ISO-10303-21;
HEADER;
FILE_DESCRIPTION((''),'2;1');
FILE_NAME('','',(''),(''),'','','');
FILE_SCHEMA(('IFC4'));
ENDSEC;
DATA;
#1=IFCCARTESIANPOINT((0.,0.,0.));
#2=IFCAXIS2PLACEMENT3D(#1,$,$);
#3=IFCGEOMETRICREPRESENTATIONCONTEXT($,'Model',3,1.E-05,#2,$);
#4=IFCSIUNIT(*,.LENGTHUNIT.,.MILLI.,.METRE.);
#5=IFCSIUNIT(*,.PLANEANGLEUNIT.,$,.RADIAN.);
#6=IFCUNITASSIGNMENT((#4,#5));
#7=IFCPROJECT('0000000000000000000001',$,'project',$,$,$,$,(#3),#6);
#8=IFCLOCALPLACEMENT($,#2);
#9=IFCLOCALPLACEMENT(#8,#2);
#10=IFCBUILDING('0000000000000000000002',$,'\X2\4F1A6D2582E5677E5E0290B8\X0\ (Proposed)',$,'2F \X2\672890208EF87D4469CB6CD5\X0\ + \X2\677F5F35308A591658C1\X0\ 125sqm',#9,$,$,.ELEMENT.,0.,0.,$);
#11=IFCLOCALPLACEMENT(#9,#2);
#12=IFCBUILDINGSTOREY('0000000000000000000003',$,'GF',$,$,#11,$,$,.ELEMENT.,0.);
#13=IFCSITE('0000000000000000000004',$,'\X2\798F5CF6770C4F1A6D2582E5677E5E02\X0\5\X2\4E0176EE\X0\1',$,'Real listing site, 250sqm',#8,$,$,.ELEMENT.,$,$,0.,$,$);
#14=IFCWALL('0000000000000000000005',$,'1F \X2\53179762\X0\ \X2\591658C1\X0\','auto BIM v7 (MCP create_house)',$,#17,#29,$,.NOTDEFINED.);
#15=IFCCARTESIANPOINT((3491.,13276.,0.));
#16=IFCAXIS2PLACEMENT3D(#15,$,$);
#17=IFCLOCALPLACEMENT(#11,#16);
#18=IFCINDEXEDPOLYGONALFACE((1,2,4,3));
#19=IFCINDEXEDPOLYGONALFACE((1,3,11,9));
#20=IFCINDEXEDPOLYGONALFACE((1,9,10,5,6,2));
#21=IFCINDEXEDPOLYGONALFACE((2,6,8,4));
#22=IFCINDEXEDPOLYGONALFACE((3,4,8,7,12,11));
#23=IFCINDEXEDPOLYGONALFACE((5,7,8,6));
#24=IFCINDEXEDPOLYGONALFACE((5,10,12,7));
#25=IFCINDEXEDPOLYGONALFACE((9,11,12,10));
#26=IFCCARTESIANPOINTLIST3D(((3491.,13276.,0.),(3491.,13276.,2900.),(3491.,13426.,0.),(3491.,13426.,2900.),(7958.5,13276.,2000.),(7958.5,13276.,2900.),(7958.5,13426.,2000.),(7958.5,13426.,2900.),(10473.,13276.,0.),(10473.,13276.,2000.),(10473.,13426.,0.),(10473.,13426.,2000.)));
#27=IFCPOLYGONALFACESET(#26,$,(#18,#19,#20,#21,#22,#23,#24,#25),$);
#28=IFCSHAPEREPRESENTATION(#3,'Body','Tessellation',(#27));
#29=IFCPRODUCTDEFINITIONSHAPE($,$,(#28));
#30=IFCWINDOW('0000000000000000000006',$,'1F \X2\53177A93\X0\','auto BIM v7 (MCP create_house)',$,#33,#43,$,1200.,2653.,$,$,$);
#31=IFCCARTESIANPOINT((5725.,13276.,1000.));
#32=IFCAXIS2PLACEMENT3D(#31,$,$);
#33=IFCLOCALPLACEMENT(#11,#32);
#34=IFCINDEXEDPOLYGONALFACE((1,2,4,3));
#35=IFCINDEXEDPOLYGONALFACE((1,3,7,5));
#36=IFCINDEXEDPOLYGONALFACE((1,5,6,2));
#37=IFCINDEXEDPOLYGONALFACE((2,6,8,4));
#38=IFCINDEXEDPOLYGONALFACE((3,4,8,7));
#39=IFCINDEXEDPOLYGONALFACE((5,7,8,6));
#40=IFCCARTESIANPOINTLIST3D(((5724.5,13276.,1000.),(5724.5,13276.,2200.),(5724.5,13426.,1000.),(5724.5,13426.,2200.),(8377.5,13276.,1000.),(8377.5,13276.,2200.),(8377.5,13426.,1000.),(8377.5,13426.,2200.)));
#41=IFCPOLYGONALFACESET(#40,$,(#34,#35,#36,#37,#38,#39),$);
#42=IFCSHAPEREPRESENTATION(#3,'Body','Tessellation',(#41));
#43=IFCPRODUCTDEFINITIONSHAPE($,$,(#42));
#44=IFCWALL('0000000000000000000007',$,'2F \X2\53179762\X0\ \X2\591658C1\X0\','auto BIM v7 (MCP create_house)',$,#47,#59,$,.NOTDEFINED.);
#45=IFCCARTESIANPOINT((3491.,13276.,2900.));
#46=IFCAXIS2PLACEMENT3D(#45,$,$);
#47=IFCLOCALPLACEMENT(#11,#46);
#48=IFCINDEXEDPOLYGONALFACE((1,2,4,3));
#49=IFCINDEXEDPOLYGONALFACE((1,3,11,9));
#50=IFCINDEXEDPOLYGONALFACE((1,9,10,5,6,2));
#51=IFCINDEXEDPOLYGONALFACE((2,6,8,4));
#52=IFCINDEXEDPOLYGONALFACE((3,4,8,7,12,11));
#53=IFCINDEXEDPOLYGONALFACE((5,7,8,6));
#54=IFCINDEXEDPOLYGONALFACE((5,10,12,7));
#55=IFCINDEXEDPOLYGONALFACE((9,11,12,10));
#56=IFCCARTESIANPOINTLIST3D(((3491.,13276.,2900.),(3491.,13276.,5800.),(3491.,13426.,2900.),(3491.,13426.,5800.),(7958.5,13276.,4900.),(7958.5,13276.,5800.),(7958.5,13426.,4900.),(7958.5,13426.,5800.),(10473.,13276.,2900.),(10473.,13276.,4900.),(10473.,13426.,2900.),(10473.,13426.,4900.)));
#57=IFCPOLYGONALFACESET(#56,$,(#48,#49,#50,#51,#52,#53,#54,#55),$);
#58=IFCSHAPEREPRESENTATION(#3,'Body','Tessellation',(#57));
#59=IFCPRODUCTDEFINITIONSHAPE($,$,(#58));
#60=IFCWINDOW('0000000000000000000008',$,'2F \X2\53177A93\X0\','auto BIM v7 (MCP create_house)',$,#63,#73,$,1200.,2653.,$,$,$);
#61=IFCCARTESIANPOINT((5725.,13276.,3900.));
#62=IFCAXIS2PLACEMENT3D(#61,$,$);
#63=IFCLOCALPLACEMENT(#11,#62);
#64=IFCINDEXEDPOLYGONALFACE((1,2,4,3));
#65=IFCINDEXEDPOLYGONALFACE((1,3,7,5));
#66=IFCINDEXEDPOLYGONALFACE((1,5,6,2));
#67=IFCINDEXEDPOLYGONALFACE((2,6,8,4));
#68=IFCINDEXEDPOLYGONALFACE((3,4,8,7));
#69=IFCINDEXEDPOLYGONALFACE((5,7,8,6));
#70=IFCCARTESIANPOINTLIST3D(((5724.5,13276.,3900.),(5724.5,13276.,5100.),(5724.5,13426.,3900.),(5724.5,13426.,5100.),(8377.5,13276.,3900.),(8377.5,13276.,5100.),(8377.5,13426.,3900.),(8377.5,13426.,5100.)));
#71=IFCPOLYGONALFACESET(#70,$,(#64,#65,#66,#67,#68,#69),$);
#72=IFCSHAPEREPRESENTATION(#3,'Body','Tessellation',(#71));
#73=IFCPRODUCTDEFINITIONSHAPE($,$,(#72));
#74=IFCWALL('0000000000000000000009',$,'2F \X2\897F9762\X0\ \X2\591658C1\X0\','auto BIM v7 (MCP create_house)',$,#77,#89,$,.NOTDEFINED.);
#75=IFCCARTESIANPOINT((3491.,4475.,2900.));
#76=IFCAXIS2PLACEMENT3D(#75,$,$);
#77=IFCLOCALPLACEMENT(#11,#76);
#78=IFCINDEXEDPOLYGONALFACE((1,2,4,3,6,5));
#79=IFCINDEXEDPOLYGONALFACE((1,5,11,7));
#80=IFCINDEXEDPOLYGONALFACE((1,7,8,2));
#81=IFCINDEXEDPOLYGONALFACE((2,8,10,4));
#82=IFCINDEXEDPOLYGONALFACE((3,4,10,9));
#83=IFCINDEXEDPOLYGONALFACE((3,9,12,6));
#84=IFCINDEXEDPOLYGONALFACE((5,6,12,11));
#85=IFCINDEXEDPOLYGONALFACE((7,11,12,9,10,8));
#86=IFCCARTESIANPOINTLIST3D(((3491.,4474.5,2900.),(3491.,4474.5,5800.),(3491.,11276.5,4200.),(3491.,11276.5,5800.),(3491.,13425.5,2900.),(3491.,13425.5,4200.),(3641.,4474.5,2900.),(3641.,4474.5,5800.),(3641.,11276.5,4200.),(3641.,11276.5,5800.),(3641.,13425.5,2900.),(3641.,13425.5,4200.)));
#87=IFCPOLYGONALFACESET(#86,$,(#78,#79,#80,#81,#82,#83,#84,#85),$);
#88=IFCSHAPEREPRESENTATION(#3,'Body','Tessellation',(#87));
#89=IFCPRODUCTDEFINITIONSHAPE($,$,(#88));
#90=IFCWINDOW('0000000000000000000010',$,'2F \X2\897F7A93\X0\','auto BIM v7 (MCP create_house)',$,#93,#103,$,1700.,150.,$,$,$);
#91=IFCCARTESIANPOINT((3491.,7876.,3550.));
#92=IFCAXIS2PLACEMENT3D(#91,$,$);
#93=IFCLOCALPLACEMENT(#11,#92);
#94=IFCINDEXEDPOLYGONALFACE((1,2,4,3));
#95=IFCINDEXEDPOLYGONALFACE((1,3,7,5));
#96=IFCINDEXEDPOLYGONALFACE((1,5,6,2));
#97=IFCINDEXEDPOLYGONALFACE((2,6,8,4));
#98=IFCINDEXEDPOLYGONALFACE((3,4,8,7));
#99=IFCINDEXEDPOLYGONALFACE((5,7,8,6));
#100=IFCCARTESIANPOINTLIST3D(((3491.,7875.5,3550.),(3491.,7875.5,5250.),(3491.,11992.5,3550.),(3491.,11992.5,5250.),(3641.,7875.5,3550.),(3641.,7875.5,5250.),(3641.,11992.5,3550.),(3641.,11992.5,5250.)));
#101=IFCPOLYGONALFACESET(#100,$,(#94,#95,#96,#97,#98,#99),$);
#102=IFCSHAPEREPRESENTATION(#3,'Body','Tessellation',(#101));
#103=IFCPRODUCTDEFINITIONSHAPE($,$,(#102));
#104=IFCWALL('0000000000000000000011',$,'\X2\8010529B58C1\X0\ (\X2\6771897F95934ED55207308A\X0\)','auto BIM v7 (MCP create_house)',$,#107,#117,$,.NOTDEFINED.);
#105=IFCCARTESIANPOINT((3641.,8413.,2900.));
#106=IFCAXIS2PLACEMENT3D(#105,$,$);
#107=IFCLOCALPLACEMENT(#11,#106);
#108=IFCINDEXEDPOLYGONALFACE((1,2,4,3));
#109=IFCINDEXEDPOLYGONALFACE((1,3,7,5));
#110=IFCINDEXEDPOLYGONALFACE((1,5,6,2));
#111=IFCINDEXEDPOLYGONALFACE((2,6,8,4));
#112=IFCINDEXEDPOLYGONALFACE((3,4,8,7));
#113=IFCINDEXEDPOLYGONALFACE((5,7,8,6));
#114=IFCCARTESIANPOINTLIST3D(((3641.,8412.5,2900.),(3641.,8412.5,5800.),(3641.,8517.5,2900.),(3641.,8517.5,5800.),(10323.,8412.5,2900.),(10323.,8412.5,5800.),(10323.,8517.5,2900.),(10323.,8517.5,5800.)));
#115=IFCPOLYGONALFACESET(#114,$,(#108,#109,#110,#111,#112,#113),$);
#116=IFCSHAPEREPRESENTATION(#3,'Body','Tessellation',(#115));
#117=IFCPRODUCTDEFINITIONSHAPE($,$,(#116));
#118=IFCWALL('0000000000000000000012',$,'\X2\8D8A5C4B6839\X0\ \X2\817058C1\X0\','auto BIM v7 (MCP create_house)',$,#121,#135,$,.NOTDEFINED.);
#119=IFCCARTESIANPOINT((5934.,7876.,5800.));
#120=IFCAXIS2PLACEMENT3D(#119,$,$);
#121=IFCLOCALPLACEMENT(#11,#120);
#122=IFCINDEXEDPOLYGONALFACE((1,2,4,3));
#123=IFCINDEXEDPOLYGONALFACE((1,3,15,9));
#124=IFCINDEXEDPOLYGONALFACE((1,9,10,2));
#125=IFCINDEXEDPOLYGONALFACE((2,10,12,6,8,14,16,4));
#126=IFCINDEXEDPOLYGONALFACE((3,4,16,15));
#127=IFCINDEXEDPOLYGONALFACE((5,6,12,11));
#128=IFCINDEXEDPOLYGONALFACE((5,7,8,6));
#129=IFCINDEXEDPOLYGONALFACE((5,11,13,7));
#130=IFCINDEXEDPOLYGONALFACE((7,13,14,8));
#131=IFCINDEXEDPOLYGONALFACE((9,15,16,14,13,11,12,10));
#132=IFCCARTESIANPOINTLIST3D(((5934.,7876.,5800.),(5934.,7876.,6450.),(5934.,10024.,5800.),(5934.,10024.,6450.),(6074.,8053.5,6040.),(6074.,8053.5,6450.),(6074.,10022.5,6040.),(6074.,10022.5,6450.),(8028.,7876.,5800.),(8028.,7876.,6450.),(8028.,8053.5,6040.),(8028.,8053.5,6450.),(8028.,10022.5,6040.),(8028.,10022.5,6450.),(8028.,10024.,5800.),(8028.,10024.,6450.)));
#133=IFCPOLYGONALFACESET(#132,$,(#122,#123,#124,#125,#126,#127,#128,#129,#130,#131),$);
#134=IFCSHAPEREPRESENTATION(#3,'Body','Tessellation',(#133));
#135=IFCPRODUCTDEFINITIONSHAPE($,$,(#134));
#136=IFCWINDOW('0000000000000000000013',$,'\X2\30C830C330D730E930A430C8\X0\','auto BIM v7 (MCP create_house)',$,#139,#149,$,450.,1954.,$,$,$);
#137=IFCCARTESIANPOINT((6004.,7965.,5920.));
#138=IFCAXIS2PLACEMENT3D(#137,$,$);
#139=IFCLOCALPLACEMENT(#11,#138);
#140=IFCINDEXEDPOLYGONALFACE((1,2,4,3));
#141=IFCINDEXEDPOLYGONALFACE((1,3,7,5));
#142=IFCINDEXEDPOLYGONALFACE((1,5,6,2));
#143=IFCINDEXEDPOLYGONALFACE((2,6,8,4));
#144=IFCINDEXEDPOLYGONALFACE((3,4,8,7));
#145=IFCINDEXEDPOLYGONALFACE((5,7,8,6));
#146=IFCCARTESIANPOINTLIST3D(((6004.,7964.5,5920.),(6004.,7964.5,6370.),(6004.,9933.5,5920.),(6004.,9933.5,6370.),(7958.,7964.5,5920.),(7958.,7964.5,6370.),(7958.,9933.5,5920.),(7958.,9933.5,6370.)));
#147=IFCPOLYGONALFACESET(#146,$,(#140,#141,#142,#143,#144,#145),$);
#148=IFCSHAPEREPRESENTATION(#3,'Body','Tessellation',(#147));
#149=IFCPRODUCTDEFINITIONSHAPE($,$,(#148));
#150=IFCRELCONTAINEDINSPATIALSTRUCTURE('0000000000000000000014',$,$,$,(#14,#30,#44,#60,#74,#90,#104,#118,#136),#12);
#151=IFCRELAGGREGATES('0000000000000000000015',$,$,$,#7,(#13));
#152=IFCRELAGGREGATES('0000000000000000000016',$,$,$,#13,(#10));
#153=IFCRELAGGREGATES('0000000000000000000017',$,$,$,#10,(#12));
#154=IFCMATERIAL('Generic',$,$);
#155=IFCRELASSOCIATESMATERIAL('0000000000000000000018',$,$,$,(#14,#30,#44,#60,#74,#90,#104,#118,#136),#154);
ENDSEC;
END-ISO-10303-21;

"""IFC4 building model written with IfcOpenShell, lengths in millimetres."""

from ifc_helpers import new_model, si_unit, frame, frame_2d, origin, place, context, project, spatial, rectangle, extrude, material, element, fill, save


model = new_model("IFC4")

# Units and contexts
model_context = context("Model", 3, precision=1e-05, world=origin())
ifc_project = project(units=[si_unit("LENGTHUNIT", "METRE", prefix="MILLI"), si_unit("PLANEANGLEUNIT", "RADIAN")], contexts=[model_context])

# Site, building, storey
site_placement = place(None, origin())
site = spatial("IfcSite", under=ifc_project, at=site_placement, Name="福島県会津若松市5丁目1", ObjectType="Real listing site, 250sqm", CompositionType="ELEMENT", RefElevation=0.0)
building_placement = place(site_placement, origin())
building = spatial("IfcBuilding", under=site, at=building_placement, Name="会津若松市邸 (Proposed)", ObjectType="2F 木造軸組構法 + 板張り外壁 125sqm", CompositionType="ELEMENT", ElevationOfRefHeight=0.0, ElevationOfTerrain=0.0)
storey_placement = place(building_placement, origin())
storey = spatial("IfcBuildingStorey", under=building, at=storey_placement, Name="GF", CompositionType="ELEMENT", Elevation=0.0)

# Wall, opening, window
ifc_material = material(Name="Generic")
wall_1_placement = place(storey_placement, frame((3491.0, 13276.0, 0.0)))
wall_1 = element("IfcWall", 1, at=wall_1_placement, inside=storey, material=ifc_material, Name="1F 北面 外壁", Description="auto BIM v7 (MCP create_house)", PredefinedType="NOTDEFINED", context=model_context, shape_type="SweptSolid", body=[
    extrude(rectangle(XDim=6982.0, YDim=150.0, at=frame_2d((3491.0, 75.0))), frame((3491.0, 13276.0, 0.0)), (0.0, 0.0, 1.0), 2900.0),
])
opening_1_placement = place(storey_placement, frame((5725.0, 13276.0, 1000.0)))
opening_1 = element("IfcOpeningElement", 2, at=opening_1_placement, cuts=wall_1, PredefinedType="NOTDEFINED", context=model_context, shape_type="SweptSolid", body=[
    extrude(rectangle(XDim=2653.0, YDim=150.0, at=frame_2d((1326.0, 75.0))), frame((5725.0, 13276.0, 1000.0)), (0.0, 0.0, 1.0), 1200.0),
])
window_1_placement = place(storey_placement, frame((5725.0, 13276.0, 1000.0)))
window_1 = element("IfcWindow", 3, at=window_1_placement, inside=storey, material=ifc_material, Name="1F 北窓", Description="auto BIM v7 (MCP create_house)", OverallHeight=1200.0, OverallWidth=2653.0, context=model_context, shape_type="SweptSolid", body=[
    extrude(rectangle(XDim=2653.0, YDim=150.0, at=frame_2d((1326.0, 75.0))), frame((5725.0, 13276.0, 1000.0)), (0.0, 0.0, 1.0), 1200.0),
])
fill(opening_1, window_1)

# Walls, openings, windows
wall_2_placement = place(storey_placement, frame((3491.0, 13276.0, 2900.0)))
wall_2 = element("IfcWall", 4, at=wall_2_placement, inside=storey, material=ifc_material, Name="2F 北面 外壁", Description="auto BIM v7 (MCP create_house)", PredefinedType="NOTDEFINED", context=model_context, shape_type="SweptSolid", body=[
    extrude(rectangle(XDim=6982.0, YDim=150.0, at=frame_2d((3491.0, 75.0))), frame((3491.0, 13276.0, 2900.0)), (0.0, 0.0, 1.0), 2900.0),
])
opening_2_placement = place(storey_placement, frame((5725.0, 13276.0, 3900.0)))
opening_2 = element("IfcOpeningElement", 5, at=opening_2_placement, cuts=wall_2, PredefinedType="NOTDEFINED", context=model_context, shape_type="SweptSolid", body=[
    extrude(rectangle(XDim=2653.0, YDim=150.0, at=frame_2d((1326.0, 75.0))), frame((5725.0, 13276.0, 3900.0)), (0.0, 0.0, 1.0), 1200.0),
])
window_2_placement = place(storey_placement, frame((5725.0, 13276.0, 3900.0)))
window_2 = element("IfcWindow", 6, at=window_2_placement, inside=storey, material=ifc_material, Name="2F 北窓", Description="auto BIM v7 (MCP create_house)", OverallHeight=1200.0, OverallWidth=2653.0, context=model_context, shape_type="SweptSolid", body=[
    extrude(rectangle(XDim=2653.0, YDim=150.0, at=frame_2d((1326.0, 75.0))), frame((5725.0, 13276.0, 3900.0)), (0.0, 0.0, 1.0), 1200.0),
])
fill(opening_2, window_2)
wall_3_placement = place(storey_placement, frame((3491.0, 4475.0, 2900.0)))
wall_3 = element("IfcWall", 7, at=wall_3_placement, inside=storey, material=ifc_material, Name="2F 西面 外壁", Description="auto BIM v7 (MCP create_house)", PredefinedType="NOTDEFINED", context=model_context, shape_type="SweptSolid", body=[
    extrude(rectangle(XDim=150.0, YDim=8951.0, at=frame_2d((75.0, 4475.0))), frame((3491.0, 4475.0, 2900.0)), (0.0, 0.0, 1.0), 2900.0),
])
opening_3_placement = place(storey_placement, frame((3491.0, 7876.0, 3550.0)))
opening_3 = element("IfcOpeningElement", 8, at=opening_3_placement, cuts=wall_3, PredefinedType="NOTDEFINED", context=model_context, shape_type="SweptSolid", body=[
    extrude(rectangle(XDim=150.0, YDim=4117.0, at=frame_2d((75.0, 2058.0))), frame((3491.0, 7876.0, 3550.0)), (0.0, 0.0, 1.0), 1700.0),
])
window_3_placement = place(storey_placement, frame((3491.0, 7876.0, 3550.0)))
window_3 = element("IfcWindow", 9, at=window_3_placement, inside=storey, material=ifc_material, Name="2F 西窓", Description="auto BIM v7 (MCP create_house)", OverallHeight=1700.0, OverallWidth=150.0, context=model_context, shape_type="SweptSolid", body=[
    extrude(rectangle(XDim=150.0, YDim=4117.0, at=frame_2d((75.0, 2058.0))), frame((3491.0, 7876.0, 3550.0)), (0.0, 0.0, 1.0), 1700.0),
])
fill(opening_3, window_3)

# Wall
wall_4_placement = place(storey_placement, frame((3641.0, 8413.0, 2900.0)))
element("IfcWall", 10, at=wall_4_placement, inside=storey, material=ifc_material, Name="耐力壁 (東西間仕切り)", Description="auto BIM v7 (MCP create_house)", PredefinedType="NOTDEFINED", context=model_context, shape_type="SweptSolid", body=[
    extrude(rectangle(XDim=6682.0, YDim=105.0, at=frame_2d((3341.0, 52.0))), frame((3641.0, 8413.0, 2900.0)), (0.0, 0.0, 1.0), 2900.0),
])

# Wall, opening, window
wall_5_placement = place(storey_placement, frame((5934.0, 7876.0, 5800.0)))
wall_5 = element("IfcWall", 11, at=wall_5_placement, inside=storey, material=ifc_material, Name="越屋根 腰壁", Description="auto BIM v7 (MCP create_house)", PredefinedType="NOTDEFINED", context=model_context, shape_type="SweptSolid", body=[
    extrude(rectangle(XDim=2094.0, YDim=2148.0, at=frame_2d((1047.0, 1074.0))), frame((5934.0, 7876.0, 5800.0)), (0.0, 0.0, 1.0), 650.0),
])
opening_4_placement = place(storey_placement, frame((6004.0, 7965.0, 5920.0)))
opening_4 = element("IfcOpeningElement", 12, at=opening_4_placement, cuts=wall_5, PredefinedType="NOTDEFINED", context=model_context, shape_type="SweptSolid", body=[
    extrude(rectangle(XDim=1954.0, YDim=1969.0, at=frame_2d((977.0, 984.0))), frame((6004.0, 7965.0, 5920.0)), (0.0, 0.0, 1.0), 450.0),
])
window_4_placement = place(storey_placement, frame((6004.0, 7965.0, 5920.0)))
window_4 = element("IfcWindow", 13, at=window_4_placement, inside=storey, material=ifc_material, Name="トップライト", Description="auto BIM v7 (MCP create_house)", OverallHeight=450.0, OverallWidth=1954.0, context=model_context, shape_type="SweptSolid", body=[
    extrude(rectangle(XDim=1954.0, YDim=1969.0, at=frame_2d((977.0, 984.0))), frame((6004.0, 7965.0, 5920.0)), (0.0, 0.0, 1.0), 450.0),
])
fill(opening_4, window_4)

save(model, "model.ifc")
